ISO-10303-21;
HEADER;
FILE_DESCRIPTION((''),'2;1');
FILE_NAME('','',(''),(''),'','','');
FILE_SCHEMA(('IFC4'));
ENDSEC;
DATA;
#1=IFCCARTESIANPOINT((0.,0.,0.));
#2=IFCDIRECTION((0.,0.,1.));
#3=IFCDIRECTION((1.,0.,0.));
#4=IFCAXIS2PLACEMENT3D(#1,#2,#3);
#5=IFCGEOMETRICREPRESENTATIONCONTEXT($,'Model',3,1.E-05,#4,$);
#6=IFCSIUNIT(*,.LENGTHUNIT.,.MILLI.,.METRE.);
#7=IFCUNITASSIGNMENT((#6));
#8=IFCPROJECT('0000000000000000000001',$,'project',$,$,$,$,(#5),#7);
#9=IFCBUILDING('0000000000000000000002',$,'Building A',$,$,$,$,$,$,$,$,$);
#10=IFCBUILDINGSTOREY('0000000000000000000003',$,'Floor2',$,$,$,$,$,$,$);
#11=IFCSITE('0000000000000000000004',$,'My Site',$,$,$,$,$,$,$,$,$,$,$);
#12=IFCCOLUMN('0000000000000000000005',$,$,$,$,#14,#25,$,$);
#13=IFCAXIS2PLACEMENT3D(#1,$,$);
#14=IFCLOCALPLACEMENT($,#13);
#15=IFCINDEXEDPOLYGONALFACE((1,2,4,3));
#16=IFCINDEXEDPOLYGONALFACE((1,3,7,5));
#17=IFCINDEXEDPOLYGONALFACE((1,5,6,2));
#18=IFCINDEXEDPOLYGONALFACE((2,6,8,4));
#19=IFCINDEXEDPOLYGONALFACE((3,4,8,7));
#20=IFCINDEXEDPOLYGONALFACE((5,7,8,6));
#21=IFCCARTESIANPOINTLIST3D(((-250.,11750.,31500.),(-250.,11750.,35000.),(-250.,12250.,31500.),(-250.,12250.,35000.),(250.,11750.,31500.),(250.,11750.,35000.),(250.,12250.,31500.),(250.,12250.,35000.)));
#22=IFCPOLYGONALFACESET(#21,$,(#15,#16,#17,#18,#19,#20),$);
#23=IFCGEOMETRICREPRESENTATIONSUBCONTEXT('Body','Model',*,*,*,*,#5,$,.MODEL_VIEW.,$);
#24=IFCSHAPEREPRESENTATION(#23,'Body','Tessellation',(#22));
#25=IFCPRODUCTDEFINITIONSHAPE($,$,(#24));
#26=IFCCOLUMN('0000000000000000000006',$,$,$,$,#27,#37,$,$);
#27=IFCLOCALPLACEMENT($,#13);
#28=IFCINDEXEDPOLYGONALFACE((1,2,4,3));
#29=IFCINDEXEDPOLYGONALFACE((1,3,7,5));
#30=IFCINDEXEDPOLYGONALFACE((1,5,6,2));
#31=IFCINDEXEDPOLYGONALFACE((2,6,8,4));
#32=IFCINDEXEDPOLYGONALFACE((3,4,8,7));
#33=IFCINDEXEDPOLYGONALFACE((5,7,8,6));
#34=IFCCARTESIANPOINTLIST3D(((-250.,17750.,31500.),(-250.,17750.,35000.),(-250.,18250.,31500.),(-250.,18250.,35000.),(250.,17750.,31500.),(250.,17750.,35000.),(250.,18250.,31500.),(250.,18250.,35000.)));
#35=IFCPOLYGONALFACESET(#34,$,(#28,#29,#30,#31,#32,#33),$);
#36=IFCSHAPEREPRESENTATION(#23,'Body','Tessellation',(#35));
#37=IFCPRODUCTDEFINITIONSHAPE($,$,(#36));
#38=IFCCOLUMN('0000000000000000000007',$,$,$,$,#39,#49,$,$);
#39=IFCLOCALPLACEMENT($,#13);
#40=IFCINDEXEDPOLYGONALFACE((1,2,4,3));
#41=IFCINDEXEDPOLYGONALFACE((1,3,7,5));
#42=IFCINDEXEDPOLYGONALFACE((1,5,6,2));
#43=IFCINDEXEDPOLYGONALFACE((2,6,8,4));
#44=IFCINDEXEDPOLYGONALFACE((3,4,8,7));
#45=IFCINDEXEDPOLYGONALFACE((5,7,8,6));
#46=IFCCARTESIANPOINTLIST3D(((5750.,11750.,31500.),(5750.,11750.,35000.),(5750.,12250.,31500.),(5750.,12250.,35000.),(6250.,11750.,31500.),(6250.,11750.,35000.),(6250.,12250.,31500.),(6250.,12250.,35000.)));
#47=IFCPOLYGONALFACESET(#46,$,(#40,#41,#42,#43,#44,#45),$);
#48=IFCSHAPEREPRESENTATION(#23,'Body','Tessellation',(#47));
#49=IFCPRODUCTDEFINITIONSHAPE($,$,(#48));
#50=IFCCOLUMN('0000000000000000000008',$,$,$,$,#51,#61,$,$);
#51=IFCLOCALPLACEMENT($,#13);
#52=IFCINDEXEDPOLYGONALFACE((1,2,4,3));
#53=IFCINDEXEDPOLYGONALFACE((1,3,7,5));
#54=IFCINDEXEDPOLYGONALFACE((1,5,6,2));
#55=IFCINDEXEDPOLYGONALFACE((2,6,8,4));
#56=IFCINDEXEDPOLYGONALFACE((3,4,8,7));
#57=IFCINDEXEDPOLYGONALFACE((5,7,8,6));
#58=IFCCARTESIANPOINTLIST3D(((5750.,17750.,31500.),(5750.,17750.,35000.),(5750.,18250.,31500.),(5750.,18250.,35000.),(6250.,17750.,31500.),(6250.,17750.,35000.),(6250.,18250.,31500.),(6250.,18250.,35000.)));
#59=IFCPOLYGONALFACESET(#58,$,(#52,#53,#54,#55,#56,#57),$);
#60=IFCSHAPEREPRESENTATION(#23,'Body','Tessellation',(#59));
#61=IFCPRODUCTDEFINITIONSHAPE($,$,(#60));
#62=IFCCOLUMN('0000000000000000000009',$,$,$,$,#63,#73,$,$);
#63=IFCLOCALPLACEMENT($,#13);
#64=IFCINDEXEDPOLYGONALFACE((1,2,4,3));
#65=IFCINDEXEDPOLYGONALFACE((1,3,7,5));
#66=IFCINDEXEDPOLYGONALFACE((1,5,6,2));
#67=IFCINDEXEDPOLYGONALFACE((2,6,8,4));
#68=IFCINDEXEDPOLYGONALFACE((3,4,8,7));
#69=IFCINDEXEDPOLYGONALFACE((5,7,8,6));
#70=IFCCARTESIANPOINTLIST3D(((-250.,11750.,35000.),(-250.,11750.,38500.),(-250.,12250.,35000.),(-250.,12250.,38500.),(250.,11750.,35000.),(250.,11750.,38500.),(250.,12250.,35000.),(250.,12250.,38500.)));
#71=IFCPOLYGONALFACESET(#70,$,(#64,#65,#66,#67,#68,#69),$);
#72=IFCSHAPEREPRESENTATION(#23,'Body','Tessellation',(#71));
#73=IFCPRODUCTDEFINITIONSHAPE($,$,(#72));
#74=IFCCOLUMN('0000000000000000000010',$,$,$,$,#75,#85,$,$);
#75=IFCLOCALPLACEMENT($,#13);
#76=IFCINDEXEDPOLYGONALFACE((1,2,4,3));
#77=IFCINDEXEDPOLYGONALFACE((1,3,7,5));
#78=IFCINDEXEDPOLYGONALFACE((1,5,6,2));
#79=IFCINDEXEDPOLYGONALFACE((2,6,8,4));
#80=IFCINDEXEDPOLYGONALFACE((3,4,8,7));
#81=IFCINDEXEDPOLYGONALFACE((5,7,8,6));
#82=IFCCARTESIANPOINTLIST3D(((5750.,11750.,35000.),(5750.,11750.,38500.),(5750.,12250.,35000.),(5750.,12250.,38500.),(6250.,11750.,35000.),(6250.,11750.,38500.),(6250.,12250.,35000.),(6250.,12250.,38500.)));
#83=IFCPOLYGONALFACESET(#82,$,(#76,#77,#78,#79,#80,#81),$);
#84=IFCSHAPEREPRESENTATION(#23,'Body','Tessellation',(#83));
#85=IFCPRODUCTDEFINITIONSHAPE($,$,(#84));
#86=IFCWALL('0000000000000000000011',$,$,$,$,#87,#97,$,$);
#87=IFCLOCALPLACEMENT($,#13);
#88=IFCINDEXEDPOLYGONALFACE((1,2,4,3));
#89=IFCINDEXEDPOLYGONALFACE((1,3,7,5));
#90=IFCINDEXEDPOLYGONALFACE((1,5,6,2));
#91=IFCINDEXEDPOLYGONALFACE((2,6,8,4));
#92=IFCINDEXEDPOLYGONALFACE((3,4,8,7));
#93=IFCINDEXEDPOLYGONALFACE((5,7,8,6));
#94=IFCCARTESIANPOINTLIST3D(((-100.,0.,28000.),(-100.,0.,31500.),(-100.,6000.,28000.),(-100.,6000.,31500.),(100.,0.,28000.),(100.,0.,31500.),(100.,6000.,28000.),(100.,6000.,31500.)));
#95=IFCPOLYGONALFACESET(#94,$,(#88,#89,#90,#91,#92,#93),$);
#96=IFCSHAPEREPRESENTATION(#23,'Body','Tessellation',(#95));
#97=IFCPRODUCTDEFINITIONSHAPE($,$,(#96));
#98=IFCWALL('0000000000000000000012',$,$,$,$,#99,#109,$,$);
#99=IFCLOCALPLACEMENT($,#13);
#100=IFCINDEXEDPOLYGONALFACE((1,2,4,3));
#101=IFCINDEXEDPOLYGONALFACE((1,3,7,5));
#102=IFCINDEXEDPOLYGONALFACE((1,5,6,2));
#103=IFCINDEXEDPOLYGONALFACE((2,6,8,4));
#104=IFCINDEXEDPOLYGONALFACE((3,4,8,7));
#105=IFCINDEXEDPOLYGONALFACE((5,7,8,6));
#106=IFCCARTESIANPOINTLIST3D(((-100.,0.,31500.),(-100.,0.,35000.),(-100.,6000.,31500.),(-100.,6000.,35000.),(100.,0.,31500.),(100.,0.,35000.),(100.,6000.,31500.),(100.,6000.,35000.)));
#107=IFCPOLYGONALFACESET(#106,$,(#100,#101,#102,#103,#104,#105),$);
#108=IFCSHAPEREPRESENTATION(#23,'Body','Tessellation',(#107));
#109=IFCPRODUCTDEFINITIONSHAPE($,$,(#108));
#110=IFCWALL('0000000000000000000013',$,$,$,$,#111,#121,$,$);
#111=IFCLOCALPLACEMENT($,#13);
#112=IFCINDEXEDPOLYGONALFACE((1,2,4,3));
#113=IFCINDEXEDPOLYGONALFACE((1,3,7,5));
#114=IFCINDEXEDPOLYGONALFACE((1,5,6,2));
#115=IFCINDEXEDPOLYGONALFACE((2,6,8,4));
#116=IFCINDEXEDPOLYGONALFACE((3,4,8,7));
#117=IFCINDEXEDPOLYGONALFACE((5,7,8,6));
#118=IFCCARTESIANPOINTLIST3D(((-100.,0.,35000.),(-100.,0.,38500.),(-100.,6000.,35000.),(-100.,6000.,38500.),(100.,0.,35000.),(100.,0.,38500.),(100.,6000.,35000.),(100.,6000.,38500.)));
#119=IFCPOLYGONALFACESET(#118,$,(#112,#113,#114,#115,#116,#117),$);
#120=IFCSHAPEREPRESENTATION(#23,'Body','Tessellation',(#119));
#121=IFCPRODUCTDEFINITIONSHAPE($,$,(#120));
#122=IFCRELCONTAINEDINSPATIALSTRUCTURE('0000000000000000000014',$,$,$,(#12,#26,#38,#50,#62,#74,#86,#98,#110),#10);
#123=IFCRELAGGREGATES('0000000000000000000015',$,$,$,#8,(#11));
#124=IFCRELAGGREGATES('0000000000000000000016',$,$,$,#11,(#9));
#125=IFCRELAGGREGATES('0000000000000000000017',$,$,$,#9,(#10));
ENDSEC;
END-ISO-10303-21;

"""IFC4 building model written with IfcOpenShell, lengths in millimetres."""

from ifc_helpers import new_model, si_unit, frame, origin_with_axes, place, context, subcontext, project, spatial, line, indexed_curve, outline, extrude, element, save


model = new_model("IFC4")

# Units and contexts
model_context = context("Model", 3, precision=1e-05, world=origin_with_axes())
body_context = subcontext(model_context, "Body", "Model", "MODEL_VIEW")
ifc_project = project(units=[si_unit("LENGTHUNIT", "METRE", prefix="MILLI")], contexts=[model_context])

# Site, building, storey
site = spatial("IfcSite", under=ifc_project, Name="My Site")
building = spatial("IfcBuilding", under=site, Name="Building A")
storey = spatial("IfcBuildingStorey", under=building, Name="Floor2")

# Columns
for number, where, z_axis, x_axis in (
    (1, (0.0, 12000.0, 31500.0), (0.0, 0.0, 1.0), (1.0, 0.0, 0.0)),
    (2, (0.0, 18000.0, 31500.0), (0.0, 0.0, 1.0), (1.0, 0.0, 0.0)),
    (3, (6000.0, 12000.0, 31500.0), (0.0, 0.0, 1.0), (1.0, 0.0, 0.0)),
    (4, (6000.0, 18000.0, 31500.0), (0.0, 0.0, 1.0), (1.0, 0.0, 0.0)),
    (5, (0.0, 12000.0, 35000.0), (0.0, 0.0, 1.0), (1.0, 0.0, 0.0)),
    (6, (6000.0, 12000.0, 35000.0), (0.0, 0.0, 1.0), (1.0, 0.0, 0.0)),
):
    element("IfcColumn", number, at=place(None, frame(where, z_axis=z_axis, x_axis=x_axis)), inside=storey, context=body_context, shape_type="SweptSolid", body=[
        extrude(outline(indexed_curve([(-250.0, -250.0), (250.0, -250.0), (250.0, 250.0), (-250.0, 250.0)], segments=[line(1, 2, 3, 4, 1)])), origin_with_axes(), (0.0, 0.0, 1.0), 3500.0),
    ])

# Walls
for number, where, z_axis, x_axis in (
    (7, (-100.0, 6000.0, 28000.0), (0.0, 0.0, 1.0), (0.0, -1.0, 0.0)),
    (8, (-100.0, 6000.0, 31500.0), (0.0, 0.0, 1.0), (0.0, -1.0, 0.0)),
    (9, (-100.0, 6000.0, 35000.0), (0.0, 0.0, 1.0), (0.0, -1.0, 0.0)),
):
    element("IfcWall", number, at=place(None, frame(where, z_axis=z_axis, x_axis=x_axis)), inside=storey, context=body_context, shape_type="SweptSolid", body=[
        extrude(outline(indexed_curve([(0.0, 0.0), (0.0, 200.0), (6000.0, 200.0), (6000.0, 0.0), (0.0, 0.0)], self_intersect=False)), origin_with_axes(), (0.0, 0.0, 1.0), 3500.0),
    ])

save(model, "model.ifc")
